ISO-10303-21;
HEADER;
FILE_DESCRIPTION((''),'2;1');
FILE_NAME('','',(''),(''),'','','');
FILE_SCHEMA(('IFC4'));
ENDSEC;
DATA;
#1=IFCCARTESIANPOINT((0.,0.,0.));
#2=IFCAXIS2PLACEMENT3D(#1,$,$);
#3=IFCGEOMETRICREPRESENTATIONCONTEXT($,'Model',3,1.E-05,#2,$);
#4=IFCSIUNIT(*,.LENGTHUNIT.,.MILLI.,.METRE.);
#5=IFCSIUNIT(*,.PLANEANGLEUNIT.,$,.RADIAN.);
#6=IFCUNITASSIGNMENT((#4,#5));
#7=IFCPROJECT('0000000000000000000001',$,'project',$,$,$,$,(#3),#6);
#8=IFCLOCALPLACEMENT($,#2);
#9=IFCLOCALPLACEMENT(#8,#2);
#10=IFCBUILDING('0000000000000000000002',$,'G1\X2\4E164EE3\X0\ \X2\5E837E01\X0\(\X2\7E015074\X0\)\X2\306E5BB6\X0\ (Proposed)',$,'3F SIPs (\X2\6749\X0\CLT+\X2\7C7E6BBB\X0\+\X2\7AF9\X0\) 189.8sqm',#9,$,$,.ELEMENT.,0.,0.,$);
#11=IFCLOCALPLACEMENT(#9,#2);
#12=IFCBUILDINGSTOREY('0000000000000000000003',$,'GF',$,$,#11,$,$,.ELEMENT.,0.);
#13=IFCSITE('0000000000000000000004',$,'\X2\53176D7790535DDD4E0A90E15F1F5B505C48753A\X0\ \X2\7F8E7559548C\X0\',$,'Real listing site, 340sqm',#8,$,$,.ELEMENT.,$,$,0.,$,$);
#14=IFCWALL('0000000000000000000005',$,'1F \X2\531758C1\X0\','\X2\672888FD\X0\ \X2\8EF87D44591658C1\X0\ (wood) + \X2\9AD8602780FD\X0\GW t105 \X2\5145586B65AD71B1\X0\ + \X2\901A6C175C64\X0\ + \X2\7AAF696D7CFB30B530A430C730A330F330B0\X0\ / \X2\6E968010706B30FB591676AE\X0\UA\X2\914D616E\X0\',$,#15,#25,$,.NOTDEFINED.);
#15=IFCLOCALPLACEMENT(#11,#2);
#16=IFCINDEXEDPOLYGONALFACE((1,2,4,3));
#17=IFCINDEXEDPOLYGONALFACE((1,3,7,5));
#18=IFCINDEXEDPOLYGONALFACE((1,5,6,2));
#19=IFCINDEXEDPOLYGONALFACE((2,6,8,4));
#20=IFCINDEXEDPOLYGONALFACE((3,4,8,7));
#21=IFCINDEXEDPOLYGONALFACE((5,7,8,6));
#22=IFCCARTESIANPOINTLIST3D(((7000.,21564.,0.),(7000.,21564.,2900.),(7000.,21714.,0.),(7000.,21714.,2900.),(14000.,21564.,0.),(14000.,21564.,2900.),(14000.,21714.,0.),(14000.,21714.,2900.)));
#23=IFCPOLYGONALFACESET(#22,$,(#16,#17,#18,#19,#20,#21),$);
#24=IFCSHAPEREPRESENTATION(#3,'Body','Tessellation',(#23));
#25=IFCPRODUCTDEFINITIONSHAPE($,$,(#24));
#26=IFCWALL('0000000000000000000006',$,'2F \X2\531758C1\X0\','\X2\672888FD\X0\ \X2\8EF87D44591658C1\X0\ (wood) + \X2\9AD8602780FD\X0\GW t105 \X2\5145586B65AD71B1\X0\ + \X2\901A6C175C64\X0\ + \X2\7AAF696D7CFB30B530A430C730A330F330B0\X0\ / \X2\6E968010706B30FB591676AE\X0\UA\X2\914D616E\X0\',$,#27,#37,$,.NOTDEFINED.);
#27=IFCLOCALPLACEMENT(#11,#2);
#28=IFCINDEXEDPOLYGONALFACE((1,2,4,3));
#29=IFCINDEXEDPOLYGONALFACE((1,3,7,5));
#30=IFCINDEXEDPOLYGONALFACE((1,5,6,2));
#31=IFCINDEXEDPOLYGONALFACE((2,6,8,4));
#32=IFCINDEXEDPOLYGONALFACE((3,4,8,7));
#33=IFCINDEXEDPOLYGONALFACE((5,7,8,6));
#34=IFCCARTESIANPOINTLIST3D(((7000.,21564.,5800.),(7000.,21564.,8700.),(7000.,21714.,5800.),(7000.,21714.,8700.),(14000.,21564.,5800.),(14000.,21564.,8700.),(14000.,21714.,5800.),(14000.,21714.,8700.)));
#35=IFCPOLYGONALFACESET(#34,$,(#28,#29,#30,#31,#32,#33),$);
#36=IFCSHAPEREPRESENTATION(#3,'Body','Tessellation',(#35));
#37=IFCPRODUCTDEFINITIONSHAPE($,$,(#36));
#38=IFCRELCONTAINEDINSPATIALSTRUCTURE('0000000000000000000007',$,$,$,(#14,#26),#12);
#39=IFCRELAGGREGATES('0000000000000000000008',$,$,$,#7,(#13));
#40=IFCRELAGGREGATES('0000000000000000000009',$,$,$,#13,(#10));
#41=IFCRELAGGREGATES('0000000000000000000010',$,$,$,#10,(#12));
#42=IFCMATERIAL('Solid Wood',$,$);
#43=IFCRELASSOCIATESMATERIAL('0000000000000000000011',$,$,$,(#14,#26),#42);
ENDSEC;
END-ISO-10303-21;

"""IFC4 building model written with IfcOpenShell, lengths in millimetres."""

from ifc_helpers import new_model, si_unit, frame, frame_2d, origin, place, context, project, spatial, rectangle, extrude, material, element, save


model = new_model("IFC4")

# Units and contexts
model_context = context("Model", 3, precision=1e-05, world=origin())
ifc_project = project(units=[si_unit("LENGTHUNIT", "METRE", prefix="MILLI"), si_unit("PLANEANGLEUNIT", "RADIAN")], contexts=[model_context])

# Site, building, storey
site_placement = place(None, origin())
site = spatial("IfcSite", under=ifc_project, at=site_placement, Name="北海道川上郡弟子屈町 美留和", ObjectType="Real listing site, 340sqm", CompositionType="ELEMENT", RefElevation=0.0)
building_placement = place(site_placement, origin())
building = spatial("IfcBuilding", under=site, at=building_placement, Name="G1世代 広縁(縁側)の家 (Proposed)", ObjectType="3F SIPs (杉CLT+籾殻+竹) 189.8sqm", CompositionType="ELEMENT", ElevationOfRefHeight=0.0, ElevationOfTerrain=0.0)
storey_placement = place(building_placement, origin())
storey = spatial("IfcBuildingStorey", under=building, at=storey_placement, Name="GF", CompositionType="ELEMENT", Elevation=0.0)

# Shared definitions
ifc_material_1 = material(Name="Solid Wood")

# Wall
wall_1_placement = place(storey_placement, frame((3500.0, 10782.0, 0.0)))
element("IfcWall", 1, at=wall_1_placement, inside=storey, material=ifc_material_1, Name="1F 北壁", Description="木製 軸組外壁 (wood) + 高性能GW t105 充填断熱 + 通気層 + 窯業系サイディング / 準耐火・外皮UA配慮", PredefinedType="NOTDEFINED", context=model_context, shape_type="SweptSolid", body=[
    extrude(rectangle(XDim=7000.0, YDim=150.0, at=frame_2d((3500.0, 75.0))), frame((3500.0, 10782.0, 0.0)), (0.0, 0.0, 1.0), 2900.0),
])

# Wall
wall_2_placement = place(storey_placement, frame((3500.0, 10782.0, 2900.0)))
element("IfcWall", 2, at=wall_2_placement, inside=storey, material=ifc_material_1, Name="2F 北壁", Description="木製 軸組外壁 (wood) + 高性能GW t105 充填断熱 + 通気層 + 窯業系サイディング / 準耐火・外皮UA配慮", PredefinedType="NOTDEFINED", context=model_context, shape_type="SweptSolid", body=[
    extrude(rectangle(XDim=7000.0, YDim=150.0, at=frame_2d((3500.0, 75.0))), frame((3500.0, 10782.0, 2900.0)), (0.0, 0.0, 1.0), 2900.0),
])

save(model, "model.ifc")
